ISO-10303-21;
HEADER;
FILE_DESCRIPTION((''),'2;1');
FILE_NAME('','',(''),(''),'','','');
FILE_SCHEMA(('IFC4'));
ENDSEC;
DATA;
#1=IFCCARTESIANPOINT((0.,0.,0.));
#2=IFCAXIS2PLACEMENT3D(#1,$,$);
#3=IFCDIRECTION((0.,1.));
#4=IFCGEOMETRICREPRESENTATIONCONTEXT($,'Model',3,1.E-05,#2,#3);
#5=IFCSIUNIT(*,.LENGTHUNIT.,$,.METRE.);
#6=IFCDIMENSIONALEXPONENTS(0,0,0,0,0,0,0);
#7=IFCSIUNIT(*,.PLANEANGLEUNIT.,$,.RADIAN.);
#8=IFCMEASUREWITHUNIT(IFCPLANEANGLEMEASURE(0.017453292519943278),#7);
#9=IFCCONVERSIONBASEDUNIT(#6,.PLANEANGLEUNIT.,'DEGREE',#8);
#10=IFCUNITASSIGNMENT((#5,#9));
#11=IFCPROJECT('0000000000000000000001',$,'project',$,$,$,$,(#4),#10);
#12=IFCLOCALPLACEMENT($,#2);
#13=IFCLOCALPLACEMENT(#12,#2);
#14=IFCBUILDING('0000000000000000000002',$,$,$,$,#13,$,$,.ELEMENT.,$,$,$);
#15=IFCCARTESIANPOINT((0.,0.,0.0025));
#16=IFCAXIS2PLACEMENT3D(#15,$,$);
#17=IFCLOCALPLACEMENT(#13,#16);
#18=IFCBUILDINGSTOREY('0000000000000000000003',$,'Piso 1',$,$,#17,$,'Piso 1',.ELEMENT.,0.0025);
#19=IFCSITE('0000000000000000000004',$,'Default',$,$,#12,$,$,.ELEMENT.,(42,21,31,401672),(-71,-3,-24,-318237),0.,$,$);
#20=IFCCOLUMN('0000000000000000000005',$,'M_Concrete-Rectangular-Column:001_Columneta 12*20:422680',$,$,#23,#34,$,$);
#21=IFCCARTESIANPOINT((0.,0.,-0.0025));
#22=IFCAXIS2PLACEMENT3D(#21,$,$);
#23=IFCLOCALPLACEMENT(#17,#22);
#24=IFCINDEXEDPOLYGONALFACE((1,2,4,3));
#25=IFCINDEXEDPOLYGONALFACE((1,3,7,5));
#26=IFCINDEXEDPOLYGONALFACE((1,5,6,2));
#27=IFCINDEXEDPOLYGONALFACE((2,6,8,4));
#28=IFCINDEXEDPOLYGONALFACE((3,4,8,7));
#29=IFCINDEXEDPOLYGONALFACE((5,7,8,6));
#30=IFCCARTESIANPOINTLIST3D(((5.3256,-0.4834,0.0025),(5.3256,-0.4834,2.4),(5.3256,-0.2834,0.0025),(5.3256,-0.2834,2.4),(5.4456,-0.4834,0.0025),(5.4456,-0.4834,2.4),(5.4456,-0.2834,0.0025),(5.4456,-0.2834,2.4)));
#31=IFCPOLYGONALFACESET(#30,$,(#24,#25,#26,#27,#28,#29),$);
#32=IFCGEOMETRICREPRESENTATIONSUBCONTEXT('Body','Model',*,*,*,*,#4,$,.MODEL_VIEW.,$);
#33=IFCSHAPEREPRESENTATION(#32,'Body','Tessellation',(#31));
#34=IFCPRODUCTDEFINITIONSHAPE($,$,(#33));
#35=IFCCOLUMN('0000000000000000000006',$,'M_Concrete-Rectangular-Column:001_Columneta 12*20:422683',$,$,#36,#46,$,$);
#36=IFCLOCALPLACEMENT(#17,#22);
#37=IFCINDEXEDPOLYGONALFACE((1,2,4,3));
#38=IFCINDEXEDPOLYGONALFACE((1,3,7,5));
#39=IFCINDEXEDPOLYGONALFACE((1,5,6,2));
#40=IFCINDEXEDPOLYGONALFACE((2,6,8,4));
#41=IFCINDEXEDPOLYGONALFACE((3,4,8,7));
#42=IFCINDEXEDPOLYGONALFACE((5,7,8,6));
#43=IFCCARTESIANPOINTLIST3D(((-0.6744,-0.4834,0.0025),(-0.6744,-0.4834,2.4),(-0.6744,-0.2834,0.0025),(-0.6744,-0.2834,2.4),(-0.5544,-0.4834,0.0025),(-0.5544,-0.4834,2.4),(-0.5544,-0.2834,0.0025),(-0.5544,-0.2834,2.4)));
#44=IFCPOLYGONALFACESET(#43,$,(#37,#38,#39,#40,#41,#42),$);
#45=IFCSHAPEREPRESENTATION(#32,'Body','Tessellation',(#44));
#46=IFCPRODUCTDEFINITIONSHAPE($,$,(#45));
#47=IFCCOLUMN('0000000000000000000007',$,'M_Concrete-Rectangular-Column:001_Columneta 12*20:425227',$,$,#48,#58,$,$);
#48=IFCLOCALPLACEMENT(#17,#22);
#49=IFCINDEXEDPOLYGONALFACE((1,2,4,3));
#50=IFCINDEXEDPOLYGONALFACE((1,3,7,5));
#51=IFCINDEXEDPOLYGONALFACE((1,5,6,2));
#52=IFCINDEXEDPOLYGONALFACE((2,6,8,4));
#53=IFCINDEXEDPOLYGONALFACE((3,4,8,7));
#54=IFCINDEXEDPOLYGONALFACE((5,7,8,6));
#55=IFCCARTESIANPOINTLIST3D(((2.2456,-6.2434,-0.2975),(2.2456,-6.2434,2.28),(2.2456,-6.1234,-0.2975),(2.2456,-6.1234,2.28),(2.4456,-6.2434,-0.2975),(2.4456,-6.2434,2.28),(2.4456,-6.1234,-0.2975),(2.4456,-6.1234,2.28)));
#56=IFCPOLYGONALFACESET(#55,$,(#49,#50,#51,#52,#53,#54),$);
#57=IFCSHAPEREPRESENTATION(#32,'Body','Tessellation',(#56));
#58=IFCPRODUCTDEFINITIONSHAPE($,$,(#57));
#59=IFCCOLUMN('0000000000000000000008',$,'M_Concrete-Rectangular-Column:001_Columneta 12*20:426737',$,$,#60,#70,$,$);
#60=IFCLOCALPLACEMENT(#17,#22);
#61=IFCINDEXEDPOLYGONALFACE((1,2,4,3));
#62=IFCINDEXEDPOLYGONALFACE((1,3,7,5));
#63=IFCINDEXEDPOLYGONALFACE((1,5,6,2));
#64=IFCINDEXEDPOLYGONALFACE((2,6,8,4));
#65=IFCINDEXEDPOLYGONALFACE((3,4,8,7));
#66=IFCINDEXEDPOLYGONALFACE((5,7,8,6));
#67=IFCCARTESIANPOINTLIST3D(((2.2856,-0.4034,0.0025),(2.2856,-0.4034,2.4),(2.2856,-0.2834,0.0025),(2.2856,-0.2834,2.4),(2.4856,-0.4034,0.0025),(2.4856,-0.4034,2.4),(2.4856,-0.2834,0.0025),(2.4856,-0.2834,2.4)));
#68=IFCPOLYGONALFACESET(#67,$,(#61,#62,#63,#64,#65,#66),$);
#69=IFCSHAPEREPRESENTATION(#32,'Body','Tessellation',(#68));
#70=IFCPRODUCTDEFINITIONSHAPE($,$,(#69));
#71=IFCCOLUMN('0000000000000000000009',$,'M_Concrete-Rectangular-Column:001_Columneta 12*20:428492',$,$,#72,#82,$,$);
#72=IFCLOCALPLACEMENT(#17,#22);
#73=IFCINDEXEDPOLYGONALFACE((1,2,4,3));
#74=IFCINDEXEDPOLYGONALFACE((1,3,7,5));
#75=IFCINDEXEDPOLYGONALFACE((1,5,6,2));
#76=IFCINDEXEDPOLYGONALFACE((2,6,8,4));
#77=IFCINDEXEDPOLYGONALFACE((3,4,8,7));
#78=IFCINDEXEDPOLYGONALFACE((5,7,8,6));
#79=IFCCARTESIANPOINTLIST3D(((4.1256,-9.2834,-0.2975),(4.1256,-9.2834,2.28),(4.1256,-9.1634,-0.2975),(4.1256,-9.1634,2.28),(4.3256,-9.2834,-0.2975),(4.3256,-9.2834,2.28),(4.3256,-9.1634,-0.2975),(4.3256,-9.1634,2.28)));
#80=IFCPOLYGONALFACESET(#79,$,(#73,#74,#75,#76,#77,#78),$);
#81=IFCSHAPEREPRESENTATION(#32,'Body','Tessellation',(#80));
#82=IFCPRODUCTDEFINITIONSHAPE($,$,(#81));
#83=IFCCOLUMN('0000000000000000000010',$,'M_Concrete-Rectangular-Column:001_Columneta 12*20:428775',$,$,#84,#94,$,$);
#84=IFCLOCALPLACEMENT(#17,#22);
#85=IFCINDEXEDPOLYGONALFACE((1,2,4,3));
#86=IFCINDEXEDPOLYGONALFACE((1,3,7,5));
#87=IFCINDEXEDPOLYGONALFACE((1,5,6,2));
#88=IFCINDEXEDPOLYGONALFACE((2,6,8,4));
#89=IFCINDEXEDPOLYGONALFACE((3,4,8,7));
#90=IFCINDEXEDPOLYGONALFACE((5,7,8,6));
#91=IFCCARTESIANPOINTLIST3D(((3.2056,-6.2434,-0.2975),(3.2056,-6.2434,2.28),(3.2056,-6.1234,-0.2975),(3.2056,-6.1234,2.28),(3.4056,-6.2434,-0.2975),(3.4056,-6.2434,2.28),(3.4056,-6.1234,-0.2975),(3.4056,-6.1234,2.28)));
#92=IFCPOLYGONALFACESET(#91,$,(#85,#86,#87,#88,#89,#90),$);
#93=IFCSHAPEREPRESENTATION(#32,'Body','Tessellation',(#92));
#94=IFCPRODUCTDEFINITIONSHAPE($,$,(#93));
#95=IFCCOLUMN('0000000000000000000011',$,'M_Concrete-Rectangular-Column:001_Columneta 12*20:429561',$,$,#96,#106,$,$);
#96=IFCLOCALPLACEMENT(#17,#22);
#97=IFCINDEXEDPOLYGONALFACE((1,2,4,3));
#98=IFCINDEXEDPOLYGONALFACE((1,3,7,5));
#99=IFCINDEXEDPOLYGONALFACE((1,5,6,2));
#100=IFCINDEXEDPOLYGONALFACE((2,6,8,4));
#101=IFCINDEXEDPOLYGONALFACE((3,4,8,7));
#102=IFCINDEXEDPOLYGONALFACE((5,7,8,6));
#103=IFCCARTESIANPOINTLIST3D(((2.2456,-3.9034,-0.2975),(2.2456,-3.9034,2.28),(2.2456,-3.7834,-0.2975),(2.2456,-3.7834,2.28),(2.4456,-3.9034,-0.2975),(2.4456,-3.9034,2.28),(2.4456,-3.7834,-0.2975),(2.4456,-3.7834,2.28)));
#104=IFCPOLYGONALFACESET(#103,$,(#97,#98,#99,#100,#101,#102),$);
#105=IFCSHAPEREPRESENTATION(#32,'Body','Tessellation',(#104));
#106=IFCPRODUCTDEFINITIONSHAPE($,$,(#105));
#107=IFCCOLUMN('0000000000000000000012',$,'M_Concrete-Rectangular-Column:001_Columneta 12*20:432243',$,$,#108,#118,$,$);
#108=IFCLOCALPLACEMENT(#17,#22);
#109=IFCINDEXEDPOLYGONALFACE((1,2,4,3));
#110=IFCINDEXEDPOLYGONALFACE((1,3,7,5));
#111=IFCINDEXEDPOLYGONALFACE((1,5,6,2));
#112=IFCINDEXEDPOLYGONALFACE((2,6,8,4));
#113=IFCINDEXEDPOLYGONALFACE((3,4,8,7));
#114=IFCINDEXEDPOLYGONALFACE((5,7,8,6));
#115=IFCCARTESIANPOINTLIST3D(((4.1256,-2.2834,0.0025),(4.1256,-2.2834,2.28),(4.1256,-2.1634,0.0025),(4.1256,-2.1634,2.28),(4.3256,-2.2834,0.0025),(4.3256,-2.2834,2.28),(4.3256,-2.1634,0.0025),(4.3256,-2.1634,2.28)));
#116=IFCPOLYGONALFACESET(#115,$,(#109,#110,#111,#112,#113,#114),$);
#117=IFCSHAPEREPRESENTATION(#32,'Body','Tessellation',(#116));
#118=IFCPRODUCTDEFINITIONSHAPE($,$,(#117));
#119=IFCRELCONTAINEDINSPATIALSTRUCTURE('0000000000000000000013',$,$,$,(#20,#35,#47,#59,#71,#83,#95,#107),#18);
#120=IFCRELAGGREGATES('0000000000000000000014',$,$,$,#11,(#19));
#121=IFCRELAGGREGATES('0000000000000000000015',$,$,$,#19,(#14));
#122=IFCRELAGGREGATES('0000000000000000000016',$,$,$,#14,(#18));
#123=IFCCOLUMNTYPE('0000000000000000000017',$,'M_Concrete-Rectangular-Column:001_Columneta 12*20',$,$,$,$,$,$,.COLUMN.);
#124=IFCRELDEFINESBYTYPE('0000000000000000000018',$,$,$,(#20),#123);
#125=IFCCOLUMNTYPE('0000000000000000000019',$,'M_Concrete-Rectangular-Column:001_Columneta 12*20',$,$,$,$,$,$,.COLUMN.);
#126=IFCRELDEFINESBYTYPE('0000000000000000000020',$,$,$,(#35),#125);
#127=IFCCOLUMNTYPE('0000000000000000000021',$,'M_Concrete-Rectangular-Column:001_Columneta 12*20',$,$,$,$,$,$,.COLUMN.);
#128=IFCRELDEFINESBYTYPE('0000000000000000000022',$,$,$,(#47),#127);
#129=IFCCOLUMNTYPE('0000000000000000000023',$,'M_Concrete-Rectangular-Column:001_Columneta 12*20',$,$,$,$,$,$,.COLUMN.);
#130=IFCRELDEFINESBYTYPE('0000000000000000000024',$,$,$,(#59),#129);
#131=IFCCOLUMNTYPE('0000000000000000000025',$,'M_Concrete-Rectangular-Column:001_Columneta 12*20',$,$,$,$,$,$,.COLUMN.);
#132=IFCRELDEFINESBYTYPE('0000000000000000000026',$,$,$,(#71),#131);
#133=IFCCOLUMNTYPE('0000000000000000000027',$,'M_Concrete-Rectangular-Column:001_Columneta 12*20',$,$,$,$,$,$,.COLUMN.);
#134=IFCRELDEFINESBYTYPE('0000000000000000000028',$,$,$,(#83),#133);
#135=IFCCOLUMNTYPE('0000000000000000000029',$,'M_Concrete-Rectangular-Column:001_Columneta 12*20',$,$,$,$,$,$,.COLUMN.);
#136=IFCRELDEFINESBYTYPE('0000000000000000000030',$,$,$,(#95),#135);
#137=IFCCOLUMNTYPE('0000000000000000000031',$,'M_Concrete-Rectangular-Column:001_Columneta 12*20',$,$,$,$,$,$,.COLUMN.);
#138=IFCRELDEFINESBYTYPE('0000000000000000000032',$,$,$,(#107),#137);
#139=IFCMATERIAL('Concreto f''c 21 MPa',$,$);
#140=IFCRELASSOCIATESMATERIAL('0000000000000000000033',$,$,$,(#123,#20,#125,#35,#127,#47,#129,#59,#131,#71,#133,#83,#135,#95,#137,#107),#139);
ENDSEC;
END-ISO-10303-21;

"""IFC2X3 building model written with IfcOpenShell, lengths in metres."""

from ifc_helpers import new_model, entity, si_unit, converted_unit, direction, frame, frame_2d, origin, origin_2d_with_axis, place, context, subcontext, project, spatial, rectangle, extrude, source, transform, mapped, material, type_object, type_shapes, element, save


model = new_model("IFC2X3")

# Units and contexts
model_context = context("Model", 3, precision=1e-05, world=origin(), true_north=direction((0.0, 1.0)))
body_context = subcontext(model_context, "Body", "Model", "MODEL_VIEW")
ifc_project = project(units=[si_unit("LENGTHUNIT", "METRE"), converted_unit("PLANEANGLEUNIT", "DEGREE", entity("IfcPlaneAngleMeasure", 0.017453292519943278), si_unit("PLANEANGLEUNIT", "RADIAN"), dimensions=[0, 0, 0, 0, 0, 0, 0])], contexts=[model_context])

# Site, building, storey
site_placement = place(None, origin())
site = spatial("IfcSite", under=ifc_project, at=site_placement, Name="Default", CompositionType="ELEMENT", RefLatitude=(42, 21, 31, 401672), RefLongitude=(-71, -3, -24, -318237), RefElevation=0.0)
building_placement = place(site_placement, origin())
building = spatial("IfcBuilding", under=site, at=building_placement, CompositionType="ELEMENT")
storey_placement = place(building_placement, frame((0.0, 0.0, 0.0025)))
storey = spatial("IfcBuildingStorey", under=building, at=storey_placement, Name="Piso 1", LongName="Piso 1", CompositionType="ELEMENT", Elevation=0.0025)

# Columns
ifc_material_1 = material(Name="Concreto f'c 21 MPa")
column_type_1 = type_object("IfcColumnType", Name="M_Concrete-Rectangular-Column:001_Columneta 12*20", PredefinedType="COLUMN", material=ifc_material_1)
shared_shape_1 = source(origin(), body_context, "Body", "SweptSolid", [
    extrude(rectangle(XDim=0.12, YDim=0.2, at=frame_2d((0.0, 0.0), x_axis=(1.0, 0.0))), frame((5.3856, -0.3834, 0.0025), z_axis=(0.0, 0.0, 1.0), x_axis=(-1.0, 0.0, 0.0)), (0.0, 0.0, 1.0), 2.3975),
])
type_shapes(column_type_1, [shared_shape_1])
column_1_placement = place(storey_placement, frame((0.0, 0.0, -0.0025)))
element("IfcColumn", 1, at=column_1_placement, inside=storey, type_object=column_type_1, material=ifc_material_1, Name="M_Concrete-Rectangular-Column:001_Columneta 12*20:422680", context=body_context, shape_type="MappedRepresentation", body=[
    mapped(shared_shape_1, transform((0.0, 0.0, 0.0), scale=1.0)),
])
column_type_2 = type_object("IfcColumnType", Name="M_Concrete-Rectangular-Column:001_Columneta 12*20", PredefinedType="COLUMN", material=ifc_material_1)
shared_shape_2 = source(origin(), body_context, "Body", "SweptSolid", [
    extrude(rectangle(XDim=0.12, YDim=0.2, at=origin_2d_with_axis()), frame((-0.6144, -0.3834, 0.0025), z_axis=(0.0, 0.0, 1.0), x_axis=(-1.0, 0.0, 0.0)), (0.0, 0.0, 1.0), 2.3975),
])
type_shapes(column_type_2, [shared_shape_2])
column_2_placement = place(storey_placement, frame((0.0, 0.0, -0.0025)))
element("IfcColumn", 2, at=column_2_placement, inside=storey, type_object=column_type_2, material=ifc_material_1, Name="M_Concrete-Rectangular-Column:001_Columneta 12*20:422683", context=body_context, shape_type="MappedRepresentation", body=[
    mapped(shared_shape_2, transform((0.0, 0.0, 0.0), scale=1.0)),
])
column_type_3 = type_object("IfcColumnType", Name="M_Concrete-Rectangular-Column:001_Columneta 12*20", PredefinedType="COLUMN", material=ifc_material_1)
shared_shape_3 = source(origin(), body_context, "Body", "SweptSolid", [
    extrude(rectangle(XDim=0.12, YDim=0.2, at=frame_2d((0.0, 0.0), x_axis=(1.0, 0.0))), frame((2.3456, -6.1834, -0.2975), z_axis=(0.0, 0.0, 1.0), x_axis=(0.0, 1.0, 0.0)), (0.0, 0.0, 1.0), 2.5775),
])
type_shapes(column_type_3, [shared_shape_3])
column_3_placement = place(storey_placement, frame((0.0, 0.0, -0.0025)))
element("IfcColumn", 3, at=column_3_placement, inside=storey, type_object=column_type_3, material=ifc_material_1, Name="M_Concrete-Rectangular-Column:001_Columneta 12*20:425227", context=body_context, shape_type="MappedRepresentation", body=[
    mapped(shared_shape_3, transform((0.0, 0.0, 0.0), scale=1.0)),
])
column_type_4 = type_object("IfcColumnType", Name="M_Concrete-Rectangular-Column:001_Columneta 12*20", PredefinedType="COLUMN", material=ifc_material_1)
shared_shape_4 = source(origin(), body_context, "Body", "SweptSolid", [
    extrude(rectangle(XDim=0.12, YDim=0.2, at=frame_2d((0.0, 0.0), x_axis=(1.0, 0.0))), frame((2.3856, -0.3434, 0.0025), z_axis=(0.0, 0.0, 1.0), x_axis=(0.0, -1.0, 0.0)), (0.0, 0.0, 1.0), 2.3975),
])
type_shapes(column_type_4, [shared_shape_4])
column_4_placement = place(storey_placement, frame((0.0, 0.0, -0.0025)))
element("IfcColumn", 4, at=column_4_placement, inside=storey, type_object=column_type_4, material=ifc_material_1, Name="M_Concrete-Rectangular-Column:001_Columneta 12*20:426737", context=body_context, shape_type="MappedRepresentation", body=[
    mapped(shared_shape_4, transform((0.0, 0.0, 0.0), scale=1.0)),
])
column_type_5 = type_object("IfcColumnType", Name="M_Concrete-Rectangular-Column:001_Columneta 12*20", PredefinedType="COLUMN", material=ifc_material_1)
shared_shape_5 = source(origin(), body_context, "Body", "SweptSolid", [
    extrude(rectangle(XDim=0.12, YDim=0.2, at=frame_2d((0.0, 0.0), x_axis=(1.0, 0.0))), frame((4.2256, -9.2234, -0.2975), z_axis=(0.0, 0.0, 1.0), x_axis=(0.0, -1.0, 0.0)), (0.0, 0.0, 1.0), 2.5775),
])
type_shapes(column_type_5, [shared_shape_5])
column_5_placement = place(storey_placement, frame((0.0, 0.0, -0.0025)))
element("IfcColumn", 5, at=column_5_placement, inside=storey, type_object=column_type_5, material=ifc_material_1, Name="M_Concrete-Rectangular-Column:001_Columneta 12*20:428492", context=body_context, shape_type="MappedRepresentation", body=[
    mapped(shared_shape_5, transform((0.0, 0.0, 0.0), scale=1.0)),
])
column_type_6 = type_object("IfcColumnType", Name="M_Concrete-Rectangular-Column:001_Columneta 12*20", PredefinedType="COLUMN", material=ifc_material_1)
shared_shape_6 = source(origin(), body_context, "Body", "SweptSolid", [
    extrude(rectangle(XDim=0.12, YDim=0.2, at=frame_2d((0.0, 0.0), x_axis=(1.0, 0.0))), frame((3.3056, -6.1834, -0.2975), z_axis=(0.0, 0.0, 1.0), x_axis=(0.0, -1.0, 0.0)), (0.0, 0.0, 1.0), 2.5775),
])
type_shapes(column_type_6, [shared_shape_6])
column_6_placement = place(storey_placement, frame((0.0, 0.0, -0.0025)))
element("IfcColumn", 6, at=column_6_placement, inside=storey, type_object=column_type_6, material=ifc_material_1, Name="M_Concrete-Rectangular-Column:001_Columneta 12*20:428775", context=body_context, shape_type="MappedRepresentation", body=[
    mapped(shared_shape_6, transform((0.0, 0.0, 0.0), scale=1.0)),
])
column_type_7 = type_object("IfcColumnType", Name="M_Concrete-Rectangular-Column:001_Columneta 12*20", PredefinedType="COLUMN", material=ifc_material_1)
shared_shape_7 = source(origin(), body_context, "Body", "SweptSolid", [
    extrude(rectangle(XDim=0.12, YDim=0.2, at=frame_2d((0.0, 0.0), x_axis=(1.0, 0.0))), frame((2.3456, -3.8434, -0.2975), z_axis=(0.0, 0.0, 1.0), x_axis=(0.0, 1.0, 0.0)), (0.0, 0.0, 1.0), 2.5775),
])
type_shapes(column_type_7, [shared_shape_7])
column_7_placement = place(storey_placement, frame((0.0, 0.0, -0.0025)))
element("IfcColumn", 7, at=column_7_placement, inside=storey, type_object=column_type_7, material=ifc_material_1, Name="M_Concrete-Rectangular-Column:001_Columneta 12*20:429561", context=body_context, shape_type="MappedRepresentation", body=[
    mapped(shared_shape_7, transform((0.0, 0.0, 0.0), scale=1.0)),
])
column_type_8 = type_object("IfcColumnType", Name="M_Concrete-Rectangular-Column:001_Columneta 12*20", PredefinedType="COLUMN", material=ifc_material_1)
shared_shape_8 = source(origin(), body_context, "Body", "SweptSolid", [
    extrude(rectangle(XDim=0.12, YDim=0.2, at=frame_2d((0.0, 0.0), x_axis=(1.0, 0.0))), frame((4.2256, -2.2234, 0.0025), z_axis=(0.0, 0.0, 1.0), x_axis=(0.0, -1.0, 0.0)), (0.0, 0.0, 1.0), 2.2775),
])
type_shapes(column_type_8, [shared_shape_8])
column_8_placement = place(storey_placement, frame((0.0, 0.0, -0.0025)))
element("IfcColumn", 8, at=column_8_placement, inside=storey, type_object=column_type_8, material=ifc_material_1, Name="M_Concrete-Rectangular-Column:001_Columneta 12*20:432243", context=body_context, shape_type="MappedRepresentation", body=[
    mapped(shared_shape_8, transform((0.0, 0.0, 0.0), scale=1.0)),
])

save(model, "model.ifc")
